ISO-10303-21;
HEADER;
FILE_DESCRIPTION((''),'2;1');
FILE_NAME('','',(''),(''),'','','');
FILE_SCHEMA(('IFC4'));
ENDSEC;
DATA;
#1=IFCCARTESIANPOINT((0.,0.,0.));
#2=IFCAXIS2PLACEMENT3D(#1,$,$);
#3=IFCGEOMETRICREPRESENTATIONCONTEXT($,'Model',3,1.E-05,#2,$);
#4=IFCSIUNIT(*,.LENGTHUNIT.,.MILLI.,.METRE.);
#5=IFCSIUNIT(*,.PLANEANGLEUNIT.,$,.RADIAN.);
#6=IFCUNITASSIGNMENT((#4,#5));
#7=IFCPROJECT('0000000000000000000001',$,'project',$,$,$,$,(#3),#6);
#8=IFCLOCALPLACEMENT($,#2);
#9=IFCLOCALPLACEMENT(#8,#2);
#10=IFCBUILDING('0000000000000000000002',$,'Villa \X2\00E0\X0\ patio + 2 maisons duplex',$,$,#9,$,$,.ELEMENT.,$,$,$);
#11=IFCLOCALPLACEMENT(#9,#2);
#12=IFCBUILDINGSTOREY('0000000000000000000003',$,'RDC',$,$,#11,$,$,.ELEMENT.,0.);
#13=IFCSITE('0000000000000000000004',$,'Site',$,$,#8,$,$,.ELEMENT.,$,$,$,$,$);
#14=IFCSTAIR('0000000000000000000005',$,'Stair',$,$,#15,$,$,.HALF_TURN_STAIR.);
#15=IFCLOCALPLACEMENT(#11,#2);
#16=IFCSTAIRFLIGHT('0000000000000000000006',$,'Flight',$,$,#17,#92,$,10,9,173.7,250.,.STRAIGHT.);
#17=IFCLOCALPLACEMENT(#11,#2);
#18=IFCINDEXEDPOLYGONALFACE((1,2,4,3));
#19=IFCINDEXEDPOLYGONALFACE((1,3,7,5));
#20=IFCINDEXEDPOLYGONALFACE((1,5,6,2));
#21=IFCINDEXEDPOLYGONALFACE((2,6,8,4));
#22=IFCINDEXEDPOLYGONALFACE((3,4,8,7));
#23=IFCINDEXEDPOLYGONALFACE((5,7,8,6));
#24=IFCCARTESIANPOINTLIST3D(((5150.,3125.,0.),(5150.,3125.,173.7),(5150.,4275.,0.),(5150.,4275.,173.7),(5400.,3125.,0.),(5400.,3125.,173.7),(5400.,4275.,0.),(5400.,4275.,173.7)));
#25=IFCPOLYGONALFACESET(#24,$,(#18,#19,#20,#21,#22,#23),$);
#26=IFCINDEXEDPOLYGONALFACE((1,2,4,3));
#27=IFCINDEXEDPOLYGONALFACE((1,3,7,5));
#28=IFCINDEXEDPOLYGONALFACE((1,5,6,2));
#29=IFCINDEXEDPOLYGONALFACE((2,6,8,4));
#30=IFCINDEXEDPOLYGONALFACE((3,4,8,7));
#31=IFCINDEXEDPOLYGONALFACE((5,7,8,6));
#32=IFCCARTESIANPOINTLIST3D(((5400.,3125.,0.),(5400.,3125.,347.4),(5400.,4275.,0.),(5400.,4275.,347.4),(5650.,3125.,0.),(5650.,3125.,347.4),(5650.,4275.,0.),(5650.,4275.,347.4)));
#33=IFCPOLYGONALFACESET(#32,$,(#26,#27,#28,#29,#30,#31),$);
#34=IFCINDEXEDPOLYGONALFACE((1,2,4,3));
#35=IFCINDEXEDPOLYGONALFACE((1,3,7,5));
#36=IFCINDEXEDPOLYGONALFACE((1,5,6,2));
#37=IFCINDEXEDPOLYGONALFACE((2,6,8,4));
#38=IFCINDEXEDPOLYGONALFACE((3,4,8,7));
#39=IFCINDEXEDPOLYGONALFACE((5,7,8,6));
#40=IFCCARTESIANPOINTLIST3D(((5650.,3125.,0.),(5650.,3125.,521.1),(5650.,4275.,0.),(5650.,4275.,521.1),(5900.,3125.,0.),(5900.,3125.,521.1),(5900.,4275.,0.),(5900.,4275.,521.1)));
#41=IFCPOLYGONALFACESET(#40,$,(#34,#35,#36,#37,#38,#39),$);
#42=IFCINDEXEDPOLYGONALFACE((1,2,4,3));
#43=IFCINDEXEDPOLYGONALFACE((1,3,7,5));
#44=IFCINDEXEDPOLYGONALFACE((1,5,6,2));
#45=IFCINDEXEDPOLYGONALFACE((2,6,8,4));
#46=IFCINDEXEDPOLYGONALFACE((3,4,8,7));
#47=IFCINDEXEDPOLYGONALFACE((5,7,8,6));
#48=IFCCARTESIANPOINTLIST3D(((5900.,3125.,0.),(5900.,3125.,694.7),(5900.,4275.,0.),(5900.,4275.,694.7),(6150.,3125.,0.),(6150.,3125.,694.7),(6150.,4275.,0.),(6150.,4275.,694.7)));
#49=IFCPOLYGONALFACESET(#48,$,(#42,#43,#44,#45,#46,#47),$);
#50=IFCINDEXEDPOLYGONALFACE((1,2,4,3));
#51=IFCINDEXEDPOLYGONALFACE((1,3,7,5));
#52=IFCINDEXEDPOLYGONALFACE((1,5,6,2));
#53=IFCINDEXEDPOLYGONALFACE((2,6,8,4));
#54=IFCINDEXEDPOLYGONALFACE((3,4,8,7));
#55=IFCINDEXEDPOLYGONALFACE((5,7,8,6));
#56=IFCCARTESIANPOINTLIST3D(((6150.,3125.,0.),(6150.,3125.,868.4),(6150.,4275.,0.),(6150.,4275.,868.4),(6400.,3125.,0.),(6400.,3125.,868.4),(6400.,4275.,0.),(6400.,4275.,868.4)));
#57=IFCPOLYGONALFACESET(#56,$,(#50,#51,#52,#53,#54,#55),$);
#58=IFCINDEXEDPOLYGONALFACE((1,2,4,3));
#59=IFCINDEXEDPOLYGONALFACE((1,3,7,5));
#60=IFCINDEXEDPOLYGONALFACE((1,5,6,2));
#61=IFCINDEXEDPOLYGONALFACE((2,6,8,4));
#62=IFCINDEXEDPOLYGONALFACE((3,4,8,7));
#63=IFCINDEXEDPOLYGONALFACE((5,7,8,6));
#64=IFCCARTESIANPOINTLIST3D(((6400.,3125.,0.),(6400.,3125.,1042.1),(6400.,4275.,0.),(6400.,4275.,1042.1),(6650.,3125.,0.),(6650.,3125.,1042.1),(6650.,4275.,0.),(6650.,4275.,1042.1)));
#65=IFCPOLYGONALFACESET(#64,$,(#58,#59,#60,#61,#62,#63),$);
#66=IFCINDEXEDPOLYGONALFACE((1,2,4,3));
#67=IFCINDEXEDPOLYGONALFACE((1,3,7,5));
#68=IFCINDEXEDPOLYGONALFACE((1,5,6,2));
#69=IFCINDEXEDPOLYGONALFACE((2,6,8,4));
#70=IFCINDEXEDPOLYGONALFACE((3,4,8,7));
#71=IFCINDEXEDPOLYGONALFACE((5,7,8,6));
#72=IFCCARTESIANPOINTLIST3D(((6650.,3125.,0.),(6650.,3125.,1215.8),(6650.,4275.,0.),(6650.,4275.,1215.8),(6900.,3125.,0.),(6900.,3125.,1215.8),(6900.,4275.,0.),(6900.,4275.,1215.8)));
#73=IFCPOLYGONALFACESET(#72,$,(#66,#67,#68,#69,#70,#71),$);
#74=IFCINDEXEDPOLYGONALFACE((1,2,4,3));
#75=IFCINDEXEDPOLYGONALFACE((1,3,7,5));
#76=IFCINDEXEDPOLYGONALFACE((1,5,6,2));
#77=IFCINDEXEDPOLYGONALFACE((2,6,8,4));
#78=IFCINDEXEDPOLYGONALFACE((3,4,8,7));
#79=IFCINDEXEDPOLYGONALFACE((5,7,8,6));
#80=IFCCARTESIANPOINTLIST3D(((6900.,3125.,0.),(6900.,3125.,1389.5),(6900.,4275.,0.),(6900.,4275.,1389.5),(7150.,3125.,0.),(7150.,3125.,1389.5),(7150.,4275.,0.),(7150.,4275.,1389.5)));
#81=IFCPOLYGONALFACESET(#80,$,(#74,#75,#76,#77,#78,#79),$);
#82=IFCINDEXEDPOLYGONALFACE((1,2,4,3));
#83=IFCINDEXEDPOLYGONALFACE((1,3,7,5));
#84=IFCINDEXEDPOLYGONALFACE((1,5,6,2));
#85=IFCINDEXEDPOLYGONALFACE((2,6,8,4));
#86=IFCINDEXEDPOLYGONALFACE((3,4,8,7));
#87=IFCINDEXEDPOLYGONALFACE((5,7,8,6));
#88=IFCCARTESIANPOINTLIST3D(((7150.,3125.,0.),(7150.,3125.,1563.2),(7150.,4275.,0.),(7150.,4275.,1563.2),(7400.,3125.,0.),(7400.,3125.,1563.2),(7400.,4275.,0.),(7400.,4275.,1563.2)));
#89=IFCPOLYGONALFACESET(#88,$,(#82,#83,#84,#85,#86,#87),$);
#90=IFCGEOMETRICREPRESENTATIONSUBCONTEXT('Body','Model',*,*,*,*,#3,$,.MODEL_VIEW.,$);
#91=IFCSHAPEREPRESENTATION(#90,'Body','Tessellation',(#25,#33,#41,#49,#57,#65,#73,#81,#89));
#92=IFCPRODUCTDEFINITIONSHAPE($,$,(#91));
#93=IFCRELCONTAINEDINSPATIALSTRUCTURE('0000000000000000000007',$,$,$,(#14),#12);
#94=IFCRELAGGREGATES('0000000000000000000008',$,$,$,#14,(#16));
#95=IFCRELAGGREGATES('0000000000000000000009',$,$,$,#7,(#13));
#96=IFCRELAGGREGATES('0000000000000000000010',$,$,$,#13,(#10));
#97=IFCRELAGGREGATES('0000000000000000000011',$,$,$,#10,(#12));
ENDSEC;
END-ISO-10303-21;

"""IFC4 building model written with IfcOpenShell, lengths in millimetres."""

from ifc_helpers import new_model, si_unit, frame, frame_2d, origin, place, context, subcontext, project, spatial, rectangle, extrude, element, aggregate, save


model = new_model("IFC4")

# Units and contexts
model_context = context("Model", 3, precision=1e-05, world=origin())
body_context = subcontext(model_context, "Body", "Model", "MODEL_VIEW")
ifc_project = project(units=[si_unit("LENGTHUNIT", "METRE", prefix="MILLI"), si_unit("PLANEANGLEUNIT", "RADIAN")], contexts=[model_context])

# Site, building, storey
site_placement = place(None, origin())
site = spatial("IfcSite", under=ifc_project, at=site_placement, Name="Site", CompositionType="ELEMENT")
building_placement = place(site_placement, origin())
building = spatial("IfcBuilding", under=site, at=building_placement, Name="Villa à patio + 2 maisons duplex", CompositionType="ELEMENT")
storey_placement = place(building_placement, origin())
storey = spatial("IfcBuildingStorey", under=building, at=storey_placement, Name="RDC", CompositionType="ELEMENT", Elevation=0.0)

# Stair, stair flight
stair_placement = place(storey_placement, origin())
stair = element("IfcStair", 1, at=stair_placement, inside=storey, Name="Stair", PredefinedType="HALF_TURN_STAIR")
stair_flight_1_placement = place(stair_placement, frame((5150.0, 3700.0, 0.0), z_axis=(0.0, 0.0, 1.0), x_axis=(1.0, 0.0, 0.0)))
stair_flight_1 = element("IfcStairFlight", 2, at=stair_flight_1_placement, Name="Flight", NumberOfRisers=10, NumberOfTreads=9, PredefinedType="STRAIGHT", RiserHeight=173.7, TreadLength=250.0, context=body_context, shape_type="SweptSolid", body=[
    extrude(rectangle(XDim=250.0, YDim=1150.0, at=frame_2d((125.0, 0.0))), origin(), (0.0, 0.0, 1.0), 173.7),
    extrude(rectangle(XDim=250.0, YDim=1150.0, at=frame_2d((375.0, 0.0))), origin(), (0.0, 0.0, 1.0), 347.4),
    extrude(rectangle(XDim=250.0, YDim=1150.0, at=frame_2d((625.0, 0.0))), origin(), (0.0, 0.0, 1.0), 521.1),
    extrude(rectangle(XDim=250.0, YDim=1150.0, at=frame_2d((875.0, 0.0))), origin(), (0.0, 0.0, 1.0), 694.7),
    extrude(rectangle(XDim=250.0, YDim=1150.0, at=frame_2d((1125.0, 0.0))), origin(), (0.0, 0.0, 1.0), 868.4),
    extrude(rectangle(XDim=250.0, YDim=1150.0, at=frame_2d((1375.0, 0.0))), origin(), (0.0, 0.0, 1.0), 1042.1),
    extrude(rectangle(XDim=250.0, YDim=1150.0, at=frame_2d((1625.0, 0.0))), origin(), (0.0, 0.0, 1.0), 1215.8),
    extrude(rectangle(XDim=250.0, YDim=1150.0, at=frame_2d((1875.0, 0.0))), origin(), (0.0, 0.0, 1.0), 1389.5),
    extrude(rectangle(XDim=250.0, YDim=1150.0, at=frame_2d((2125.0, 0.0))), origin(), (0.0, 0.0, 1.0), 1563.2),
])
aggregate(stair, [stair_flight_1])

save(model, "model.ifc")
